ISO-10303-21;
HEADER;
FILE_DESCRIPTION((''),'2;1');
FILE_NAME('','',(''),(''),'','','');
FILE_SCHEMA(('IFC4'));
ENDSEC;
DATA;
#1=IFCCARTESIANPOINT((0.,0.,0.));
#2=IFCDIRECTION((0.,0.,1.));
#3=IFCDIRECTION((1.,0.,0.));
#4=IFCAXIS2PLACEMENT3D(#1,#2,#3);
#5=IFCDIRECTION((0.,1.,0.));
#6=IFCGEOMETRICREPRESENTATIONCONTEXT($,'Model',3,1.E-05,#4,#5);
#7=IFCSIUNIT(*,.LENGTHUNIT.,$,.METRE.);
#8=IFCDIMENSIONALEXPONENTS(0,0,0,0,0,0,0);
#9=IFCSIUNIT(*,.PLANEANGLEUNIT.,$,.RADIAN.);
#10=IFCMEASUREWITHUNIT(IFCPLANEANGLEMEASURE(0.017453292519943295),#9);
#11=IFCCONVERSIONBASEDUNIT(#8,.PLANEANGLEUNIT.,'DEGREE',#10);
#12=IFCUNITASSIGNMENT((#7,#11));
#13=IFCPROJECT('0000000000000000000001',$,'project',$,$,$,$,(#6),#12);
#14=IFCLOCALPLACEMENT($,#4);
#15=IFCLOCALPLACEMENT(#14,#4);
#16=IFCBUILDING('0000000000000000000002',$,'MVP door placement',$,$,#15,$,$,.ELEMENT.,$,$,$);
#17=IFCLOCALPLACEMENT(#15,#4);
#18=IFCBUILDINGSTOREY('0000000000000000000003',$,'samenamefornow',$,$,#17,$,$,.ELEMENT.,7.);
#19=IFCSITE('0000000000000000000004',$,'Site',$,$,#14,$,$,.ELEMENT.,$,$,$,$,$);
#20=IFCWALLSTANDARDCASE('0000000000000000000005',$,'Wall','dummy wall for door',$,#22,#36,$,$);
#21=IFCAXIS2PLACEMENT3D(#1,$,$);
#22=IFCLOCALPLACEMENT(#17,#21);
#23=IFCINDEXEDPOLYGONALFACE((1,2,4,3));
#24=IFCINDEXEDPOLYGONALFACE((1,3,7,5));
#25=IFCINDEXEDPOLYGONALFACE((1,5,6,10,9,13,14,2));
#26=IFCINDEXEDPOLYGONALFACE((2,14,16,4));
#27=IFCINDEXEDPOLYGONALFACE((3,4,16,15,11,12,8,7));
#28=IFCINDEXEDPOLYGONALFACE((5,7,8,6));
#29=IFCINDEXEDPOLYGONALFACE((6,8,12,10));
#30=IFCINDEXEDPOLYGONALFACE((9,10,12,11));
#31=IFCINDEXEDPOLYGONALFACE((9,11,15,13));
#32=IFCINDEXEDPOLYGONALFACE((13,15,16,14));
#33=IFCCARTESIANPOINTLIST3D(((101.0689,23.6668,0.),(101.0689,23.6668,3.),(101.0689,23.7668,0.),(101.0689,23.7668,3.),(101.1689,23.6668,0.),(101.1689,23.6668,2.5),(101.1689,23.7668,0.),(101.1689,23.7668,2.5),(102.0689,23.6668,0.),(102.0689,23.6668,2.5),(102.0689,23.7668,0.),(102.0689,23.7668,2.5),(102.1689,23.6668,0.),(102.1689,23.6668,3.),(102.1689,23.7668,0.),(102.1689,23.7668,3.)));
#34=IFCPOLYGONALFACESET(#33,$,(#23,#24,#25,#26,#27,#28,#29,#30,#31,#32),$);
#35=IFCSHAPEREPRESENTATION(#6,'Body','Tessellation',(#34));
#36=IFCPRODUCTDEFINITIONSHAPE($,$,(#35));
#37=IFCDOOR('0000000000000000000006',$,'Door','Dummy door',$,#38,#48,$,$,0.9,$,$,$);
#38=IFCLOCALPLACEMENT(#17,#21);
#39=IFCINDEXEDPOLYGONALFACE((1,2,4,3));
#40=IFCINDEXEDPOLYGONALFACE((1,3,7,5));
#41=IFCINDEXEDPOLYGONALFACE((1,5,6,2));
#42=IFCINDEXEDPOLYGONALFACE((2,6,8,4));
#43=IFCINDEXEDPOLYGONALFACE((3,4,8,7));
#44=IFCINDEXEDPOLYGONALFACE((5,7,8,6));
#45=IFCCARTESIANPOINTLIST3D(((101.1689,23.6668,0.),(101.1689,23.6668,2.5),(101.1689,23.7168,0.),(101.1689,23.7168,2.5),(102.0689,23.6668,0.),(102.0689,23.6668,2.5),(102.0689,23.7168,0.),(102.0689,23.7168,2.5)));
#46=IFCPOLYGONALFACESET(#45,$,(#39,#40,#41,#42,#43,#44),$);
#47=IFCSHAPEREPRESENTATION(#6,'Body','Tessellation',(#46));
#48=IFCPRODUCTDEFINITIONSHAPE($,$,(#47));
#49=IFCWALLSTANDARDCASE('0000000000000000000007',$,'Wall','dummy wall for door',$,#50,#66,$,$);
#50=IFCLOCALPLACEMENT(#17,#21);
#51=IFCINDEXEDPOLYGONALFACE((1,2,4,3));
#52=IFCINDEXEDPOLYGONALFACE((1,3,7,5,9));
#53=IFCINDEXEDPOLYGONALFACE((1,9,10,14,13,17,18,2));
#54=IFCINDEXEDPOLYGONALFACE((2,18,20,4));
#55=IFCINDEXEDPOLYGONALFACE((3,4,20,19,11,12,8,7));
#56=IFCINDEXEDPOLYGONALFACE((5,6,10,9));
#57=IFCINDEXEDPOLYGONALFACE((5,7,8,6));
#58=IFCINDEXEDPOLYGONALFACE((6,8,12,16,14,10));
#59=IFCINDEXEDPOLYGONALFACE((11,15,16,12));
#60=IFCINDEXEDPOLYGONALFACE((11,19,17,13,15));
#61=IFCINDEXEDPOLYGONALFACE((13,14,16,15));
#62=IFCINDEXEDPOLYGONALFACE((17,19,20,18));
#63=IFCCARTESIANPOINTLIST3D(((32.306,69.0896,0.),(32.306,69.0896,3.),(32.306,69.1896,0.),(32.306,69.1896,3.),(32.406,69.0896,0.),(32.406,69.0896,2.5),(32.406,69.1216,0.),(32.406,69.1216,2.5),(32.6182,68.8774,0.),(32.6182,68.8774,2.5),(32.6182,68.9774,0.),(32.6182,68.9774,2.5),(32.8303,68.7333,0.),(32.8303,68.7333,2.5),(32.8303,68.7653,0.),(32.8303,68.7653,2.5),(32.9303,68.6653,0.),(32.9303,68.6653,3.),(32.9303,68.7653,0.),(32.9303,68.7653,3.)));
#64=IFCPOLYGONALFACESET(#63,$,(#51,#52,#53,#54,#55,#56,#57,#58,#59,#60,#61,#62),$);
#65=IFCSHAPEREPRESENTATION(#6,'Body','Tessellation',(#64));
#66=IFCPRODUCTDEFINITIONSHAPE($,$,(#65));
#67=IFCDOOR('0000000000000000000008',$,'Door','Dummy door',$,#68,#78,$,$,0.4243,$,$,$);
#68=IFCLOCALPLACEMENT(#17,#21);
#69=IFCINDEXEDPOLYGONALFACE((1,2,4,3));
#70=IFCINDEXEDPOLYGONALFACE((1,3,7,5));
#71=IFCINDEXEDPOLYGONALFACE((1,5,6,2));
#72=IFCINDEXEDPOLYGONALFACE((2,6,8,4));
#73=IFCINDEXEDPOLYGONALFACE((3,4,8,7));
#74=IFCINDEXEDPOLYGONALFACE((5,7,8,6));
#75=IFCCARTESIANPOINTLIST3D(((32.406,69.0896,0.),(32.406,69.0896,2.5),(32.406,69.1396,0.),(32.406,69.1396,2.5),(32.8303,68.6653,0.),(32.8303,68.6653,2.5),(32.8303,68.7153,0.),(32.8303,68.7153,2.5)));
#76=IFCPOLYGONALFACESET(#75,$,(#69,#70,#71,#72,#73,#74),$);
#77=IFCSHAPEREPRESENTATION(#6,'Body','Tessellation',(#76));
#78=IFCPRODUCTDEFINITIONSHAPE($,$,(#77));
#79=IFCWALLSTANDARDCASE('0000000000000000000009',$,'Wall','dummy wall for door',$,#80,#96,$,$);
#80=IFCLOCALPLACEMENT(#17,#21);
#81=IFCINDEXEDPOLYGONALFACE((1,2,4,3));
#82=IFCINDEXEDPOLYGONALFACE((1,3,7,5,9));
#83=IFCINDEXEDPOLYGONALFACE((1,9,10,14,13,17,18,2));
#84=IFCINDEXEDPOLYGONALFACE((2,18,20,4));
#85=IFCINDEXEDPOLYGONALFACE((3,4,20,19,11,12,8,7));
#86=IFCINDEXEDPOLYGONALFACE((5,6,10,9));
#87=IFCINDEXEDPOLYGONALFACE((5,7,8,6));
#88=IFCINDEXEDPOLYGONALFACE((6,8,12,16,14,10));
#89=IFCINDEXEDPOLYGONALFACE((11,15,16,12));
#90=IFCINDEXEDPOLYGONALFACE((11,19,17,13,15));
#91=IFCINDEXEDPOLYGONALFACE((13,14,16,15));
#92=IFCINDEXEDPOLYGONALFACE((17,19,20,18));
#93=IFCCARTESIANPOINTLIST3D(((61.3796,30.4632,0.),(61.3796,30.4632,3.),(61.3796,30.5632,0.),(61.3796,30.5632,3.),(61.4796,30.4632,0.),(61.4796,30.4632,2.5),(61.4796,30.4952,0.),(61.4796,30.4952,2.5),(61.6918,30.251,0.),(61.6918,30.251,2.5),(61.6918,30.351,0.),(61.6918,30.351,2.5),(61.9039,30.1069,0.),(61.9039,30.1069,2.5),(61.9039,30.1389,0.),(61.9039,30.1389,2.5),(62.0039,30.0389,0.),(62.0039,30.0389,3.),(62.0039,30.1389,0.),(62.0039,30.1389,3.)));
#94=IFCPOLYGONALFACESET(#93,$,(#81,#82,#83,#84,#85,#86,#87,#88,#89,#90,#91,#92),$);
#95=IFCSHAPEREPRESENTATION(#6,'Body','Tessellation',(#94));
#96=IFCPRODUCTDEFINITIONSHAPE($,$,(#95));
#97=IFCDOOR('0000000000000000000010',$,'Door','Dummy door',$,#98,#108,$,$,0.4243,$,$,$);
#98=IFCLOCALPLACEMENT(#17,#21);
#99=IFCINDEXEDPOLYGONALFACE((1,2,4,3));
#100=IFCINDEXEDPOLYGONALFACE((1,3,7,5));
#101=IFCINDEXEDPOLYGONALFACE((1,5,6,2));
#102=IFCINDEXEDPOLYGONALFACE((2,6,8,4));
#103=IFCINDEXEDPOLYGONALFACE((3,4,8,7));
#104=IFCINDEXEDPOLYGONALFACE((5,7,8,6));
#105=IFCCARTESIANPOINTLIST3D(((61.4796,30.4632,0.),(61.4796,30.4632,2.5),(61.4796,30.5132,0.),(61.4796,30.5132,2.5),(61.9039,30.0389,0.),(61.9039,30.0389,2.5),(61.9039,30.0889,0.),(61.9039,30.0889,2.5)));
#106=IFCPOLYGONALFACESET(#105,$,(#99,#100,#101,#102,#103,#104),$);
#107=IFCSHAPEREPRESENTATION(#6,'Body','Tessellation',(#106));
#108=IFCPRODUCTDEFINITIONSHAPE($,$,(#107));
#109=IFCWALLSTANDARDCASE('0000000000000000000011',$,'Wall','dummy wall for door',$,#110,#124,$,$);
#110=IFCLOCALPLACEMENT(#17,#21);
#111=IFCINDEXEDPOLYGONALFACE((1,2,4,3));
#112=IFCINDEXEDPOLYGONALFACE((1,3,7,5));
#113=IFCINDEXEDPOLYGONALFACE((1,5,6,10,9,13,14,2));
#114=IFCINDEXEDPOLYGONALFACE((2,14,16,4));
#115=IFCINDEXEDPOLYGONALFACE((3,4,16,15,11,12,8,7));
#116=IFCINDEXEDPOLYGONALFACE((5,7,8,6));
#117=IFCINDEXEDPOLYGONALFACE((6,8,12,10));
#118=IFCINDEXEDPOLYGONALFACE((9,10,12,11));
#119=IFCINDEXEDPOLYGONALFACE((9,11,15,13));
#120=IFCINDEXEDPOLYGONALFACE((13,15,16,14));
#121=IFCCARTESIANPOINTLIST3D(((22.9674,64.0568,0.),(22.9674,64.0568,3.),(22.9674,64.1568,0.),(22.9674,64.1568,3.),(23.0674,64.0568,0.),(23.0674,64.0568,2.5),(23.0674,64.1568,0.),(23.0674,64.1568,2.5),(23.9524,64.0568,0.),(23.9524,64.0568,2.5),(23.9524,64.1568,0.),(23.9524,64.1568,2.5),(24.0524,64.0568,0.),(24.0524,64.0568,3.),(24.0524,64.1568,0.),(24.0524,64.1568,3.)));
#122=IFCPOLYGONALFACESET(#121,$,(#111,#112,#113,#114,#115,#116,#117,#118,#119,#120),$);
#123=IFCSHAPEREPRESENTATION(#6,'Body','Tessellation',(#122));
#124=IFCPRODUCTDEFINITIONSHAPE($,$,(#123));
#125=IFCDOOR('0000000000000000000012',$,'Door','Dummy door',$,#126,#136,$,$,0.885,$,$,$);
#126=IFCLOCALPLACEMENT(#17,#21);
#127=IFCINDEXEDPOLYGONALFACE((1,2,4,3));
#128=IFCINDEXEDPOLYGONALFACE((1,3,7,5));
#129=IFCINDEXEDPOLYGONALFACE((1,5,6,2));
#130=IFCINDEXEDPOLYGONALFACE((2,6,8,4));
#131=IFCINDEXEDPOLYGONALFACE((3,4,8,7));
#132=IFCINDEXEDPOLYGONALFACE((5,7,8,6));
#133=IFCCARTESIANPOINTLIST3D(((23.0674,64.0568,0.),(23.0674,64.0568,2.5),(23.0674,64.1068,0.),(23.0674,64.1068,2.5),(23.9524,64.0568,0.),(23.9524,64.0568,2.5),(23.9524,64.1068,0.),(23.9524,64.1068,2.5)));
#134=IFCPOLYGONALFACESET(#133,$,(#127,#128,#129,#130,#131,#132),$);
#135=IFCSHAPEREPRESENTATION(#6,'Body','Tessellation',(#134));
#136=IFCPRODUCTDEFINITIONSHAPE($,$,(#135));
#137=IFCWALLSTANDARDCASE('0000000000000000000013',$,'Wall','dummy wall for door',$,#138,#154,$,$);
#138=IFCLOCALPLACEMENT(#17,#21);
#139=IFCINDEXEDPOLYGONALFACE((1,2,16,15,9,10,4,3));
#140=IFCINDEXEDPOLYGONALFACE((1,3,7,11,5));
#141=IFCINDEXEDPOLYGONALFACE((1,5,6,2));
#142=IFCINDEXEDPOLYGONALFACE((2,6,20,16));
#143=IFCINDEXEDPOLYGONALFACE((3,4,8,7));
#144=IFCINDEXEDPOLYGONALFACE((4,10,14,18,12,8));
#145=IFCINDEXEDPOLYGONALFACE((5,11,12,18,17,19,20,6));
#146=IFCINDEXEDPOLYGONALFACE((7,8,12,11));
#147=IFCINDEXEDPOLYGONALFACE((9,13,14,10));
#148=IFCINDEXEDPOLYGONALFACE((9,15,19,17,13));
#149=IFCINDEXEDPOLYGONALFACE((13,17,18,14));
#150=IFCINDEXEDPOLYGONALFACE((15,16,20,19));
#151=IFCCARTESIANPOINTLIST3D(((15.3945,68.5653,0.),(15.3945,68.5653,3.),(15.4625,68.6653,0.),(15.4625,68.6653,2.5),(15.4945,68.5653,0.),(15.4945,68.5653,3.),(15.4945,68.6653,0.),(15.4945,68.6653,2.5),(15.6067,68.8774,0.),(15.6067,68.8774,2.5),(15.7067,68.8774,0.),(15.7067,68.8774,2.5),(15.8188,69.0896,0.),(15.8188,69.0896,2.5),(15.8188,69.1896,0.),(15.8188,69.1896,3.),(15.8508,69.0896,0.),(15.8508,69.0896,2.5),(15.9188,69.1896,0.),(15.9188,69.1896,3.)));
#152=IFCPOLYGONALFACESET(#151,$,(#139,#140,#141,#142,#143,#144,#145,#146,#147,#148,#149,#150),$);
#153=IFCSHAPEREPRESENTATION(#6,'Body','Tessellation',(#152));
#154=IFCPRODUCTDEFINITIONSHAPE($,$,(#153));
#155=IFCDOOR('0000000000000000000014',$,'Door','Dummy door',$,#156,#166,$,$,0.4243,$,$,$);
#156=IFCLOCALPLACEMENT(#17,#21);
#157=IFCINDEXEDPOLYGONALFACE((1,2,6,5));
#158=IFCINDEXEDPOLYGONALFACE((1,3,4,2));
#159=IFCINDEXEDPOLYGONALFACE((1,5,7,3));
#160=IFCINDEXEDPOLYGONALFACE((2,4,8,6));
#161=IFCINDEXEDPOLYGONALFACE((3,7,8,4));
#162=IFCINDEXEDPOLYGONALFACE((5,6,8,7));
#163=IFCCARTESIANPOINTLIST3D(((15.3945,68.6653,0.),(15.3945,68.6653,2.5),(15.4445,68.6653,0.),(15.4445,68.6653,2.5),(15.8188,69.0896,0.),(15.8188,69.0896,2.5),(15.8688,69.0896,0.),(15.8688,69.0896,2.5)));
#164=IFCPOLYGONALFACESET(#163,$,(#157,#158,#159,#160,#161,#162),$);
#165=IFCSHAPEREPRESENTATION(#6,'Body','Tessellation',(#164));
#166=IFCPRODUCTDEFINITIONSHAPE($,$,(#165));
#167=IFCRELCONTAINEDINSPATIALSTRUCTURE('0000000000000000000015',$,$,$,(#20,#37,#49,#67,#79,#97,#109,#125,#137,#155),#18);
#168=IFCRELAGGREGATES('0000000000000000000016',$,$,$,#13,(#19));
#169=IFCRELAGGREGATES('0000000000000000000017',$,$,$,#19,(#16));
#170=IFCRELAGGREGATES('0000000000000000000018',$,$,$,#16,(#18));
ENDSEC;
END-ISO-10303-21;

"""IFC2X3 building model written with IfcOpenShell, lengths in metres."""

from ifc_helpers import new_model, entity, si_unit, converted_unit, direction, origin_with_axes, place, context, project, spatial, polyline, outline, extrude, element, fill, save


model = new_model("IFC2X3")

# Units and contexts
model_context = context("Model", 3, precision=1e-05, world=origin_with_axes(), true_north=direction((0.0, 1.0, 0.0)))
ifc_project = project(units=[si_unit("LENGTHUNIT", "METRE"), converted_unit("PLANEANGLEUNIT", "DEGREE", entity("IfcPlaneAngleMeasure", 0.017453292519943295), si_unit("PLANEANGLEUNIT", "RADIAN"), dimensions=[0, 0, 0, 0, 0, 0, 0])], contexts=[model_context])

# Site, building, storey
site_placement = place(None, origin_with_axes())
site = spatial("IfcSite", under=ifc_project, at=site_placement, Name="Site", CompositionType="ELEMENT")
building_placement = place(site_placement, origin_with_axes())
building = spatial("IfcBuilding", under=site, at=building_placement, Name="MVP door placement", CompositionType="ELEMENT")
storey_placement = place(building_placement, origin_with_axes())
storey = spatial("IfcBuildingStorey", under=building, at=storey_placement, Name="samenamefornow", CompositionType="ELEMENT", Elevation=7.0)

# Walls, openings, doors
wall_1_placement = place(storey_placement, origin_with_axes())
wall_1 = element("IfcWallStandardCase", 1, at=wall_1_placement, inside=storey, Name="Wall", Description="dummy wall for door", context=model_context, shape_type="SweptSolid", body=[
    extrude(outline(polyline([(101.0689, 23.6668, 0.0), (102.1689, 23.6668, 0.0), (102.1689, 23.7668, 0.0), (101.0689, 23.7668, 0.0), (101.0689, 23.6668, 0.0)])), origin_with_axes(), (0.0, 0.0, 1.0), 3.0),
])
opening_1_placement = place(wall_1_placement, origin_with_axes())
opening_1 = element("IfcOpeningElement", 2, at=opening_1_placement, cuts=wall_1, context=model_context, shape_type="SweptSolid", body=[
    extrude(outline(polyline([(101.1689, 23.6668, 0.0), (102.0689, 23.6668, 0.0), (102.0689, 23.7668, 0.0), (101.1689, 23.7668, 0.0), (101.1689, 23.6668, 0.0)])), origin_with_axes(), (0.0, 0.0, 1.0), 2.5),
])
door_1_placement = place(opening_1_placement, origin_with_axes())
door_1 = element("IfcDoor", 3, at=door_1_placement, inside=storey, Name="Door", Description="Dummy door", OverallWidth=0.9, context=model_context, shape_type="SweptSolid", body=[
    extrude(outline(polyline([(101.1689, 23.6668, 0.0), (102.0689, 23.6668, 0.0), (102.0689, 23.7168, 0.0), (101.1689, 23.7168, 0.0), (101.1689, 23.6668, 0.0)])), origin_with_axes(), (0.0, 0.0, 1.0), 2.5),
])
fill(opening_1, door_1)
wall_2_placement = place(storey_placement, origin_with_axes())
wall_2 = element("IfcWallStandardCase", 4, at=wall_2_placement, inside=storey, Name="Wall", Description="dummy wall for door", context=model_context, shape_type="SweptSolid", body=[
    extrude(outline(polyline([(32.306, 69.0896, 0.0), (32.9303, 68.6653, 0.0), (32.9303, 68.7653, 0.0), (32.306, 69.1896, 0.0), (32.306, 69.0896, 0.0)])), origin_with_axes(), (0.0, 0.0, 1.0), 3.0),
])
opening_2_placement = place(wall_2_placement, origin_with_axes())
opening_2 = element("IfcOpeningElement", 5, at=opening_2_placement, cuts=wall_2, context=model_context, shape_type="SweptSolid", body=[
    extrude(outline(polyline([(32.406, 69.0896, 0.0), (32.8303, 68.6653, 0.0), (32.8303, 68.7653, 0.0), (32.406, 69.1896, 0.0), (32.406, 69.0896, 0.0)])), origin_with_axes(), (0.0, 0.0, 1.0), 2.5),
])
door_2_placement = place(opening_2_placement, origin_with_axes())
door_2 = element("IfcDoor", 6, at=door_2_placement, inside=storey, Name="Door", Description="Dummy door", OverallWidth=0.4243, context=model_context, shape_type="SweptSolid", body=[
    extrude(outline(polyline([(32.406, 69.0896, 0.0), (32.8303, 68.6653, 0.0), (32.8303, 68.7153, 0.0), (32.406, 69.1396, 0.0), (32.406, 69.0896, 0.0)])), origin_with_axes(), (0.0, 0.0, 1.0), 2.5),
])
fill(opening_2, door_2)
wall_3_placement = place(storey_placement, origin_with_axes())
wall_3 = element("IfcWallStandardCase", 7, at=wall_3_placement, inside=storey, Name="Wall", Description="dummy wall for door", context=model_context, shape_type="SweptSolid", body=[
    extrude(outline(polyline([(61.3796, 30.4632, 0.0), (62.0039, 30.0389, 0.0), (62.0039, 30.1389, 0.0), (61.3796, 30.5632, 0.0), (61.3796, 30.4632, 0.0)])), origin_with_axes(), (0.0, 0.0, 1.0), 3.0),
])
opening_3_placement = place(wall_3_placement, origin_with_axes())
opening_3 = element("IfcOpeningElement", 8, at=opening_3_placement, cuts=wall_3, context=model_context, shape_type="SweptSolid", body=[
    extrude(outline(polyline([(61.4796, 30.4632, 0.0), (61.9039, 30.0389, 0.0), (61.9039, 30.1389, 0.0), (61.4796, 30.5632, 0.0), (61.4796, 30.4632, 0.0)])), origin_with_axes(), (0.0, 0.0, 1.0), 2.5),
])
door_3_placement = place(opening_3_placement, origin_with_axes())
door_3 = element("IfcDoor", 9, at=door_3_placement, inside=storey, Name="Door", Description="Dummy door", OverallWidth=0.4243, context=model_context, shape_type="SweptSolid", body=[
    extrude(outline(polyline([(61.4796, 30.4632, 0.0), (61.9039, 30.0389, 0.0), (61.9039, 30.0889, 0.0), (61.4796, 30.5132, 0.0), (61.4796, 30.4632, 0.0)])), origin_with_axes(), (0.0, 0.0, 1.0), 2.5),
])
fill(opening_3, door_3)
wall_4_placement = place(storey_placement, origin_with_axes())
wall_4 = element("IfcWallStandardCase", 10, at=wall_4_placement, inside=storey, Name="Wall", Description="dummy wall for door", context=model_context, shape_type="SweptSolid", body=[
    extrude(outline(polyline([(22.9674, 64.0568, 0.0), (24.0524, 64.0568, 0.0), (24.0524, 64.1568, 0.0), (22.9674, 64.1568, 0.0), (22.9674, 64.0568, 0.0)])), origin_with_axes(), (0.0, 0.0, 1.0), 3.0),
])
opening_4_placement = place(wall_4_placement, origin_with_axes())
opening_4 = element("IfcOpeningElement", 11, at=opening_4_placement, cuts=wall_4, context=model_context, shape_type="SweptSolid", body=[
    extrude(outline(polyline([(23.0674, 64.0568, 0.0), (23.9524, 64.0568, 0.0), (23.9524, 64.1568, 0.0), (23.0674, 64.1568, 0.0), (23.0674, 64.0568, 0.0)])), origin_with_axes(), (0.0, 0.0, 1.0), 2.5),
])
door_4_placement = place(opening_4_placement, origin_with_axes())
door_4 = element("IfcDoor", 12, at=door_4_placement, inside=storey, Name="Door", Description="Dummy door", OverallWidth=0.885, context=model_context, shape_type="SweptSolid", body=[
    extrude(outline(polyline([(23.0674, 64.0568, 0.0), (23.9524, 64.0568, 0.0), (23.9524, 64.1068, 0.0), (23.0674, 64.1068, 0.0), (23.0674, 64.0568, 0.0)])), origin_with_axes(), (0.0, 0.0, 1.0), 2.5),
])
fill(opening_4, door_4)
wall_5_placement = place(storey_placement, origin_with_axes())
wall_5 = element("IfcWallStandardCase", 13, at=wall_5_placement, inside=storey, Name="Wall", Description="dummy wall for door", context=model_context, shape_type="SweptSolid", body=[
    extrude(outline(polyline([(15.8188, 69.1896, 0.0), (15.3945, 68.5653, 0.0), (15.4945, 68.5653, 0.0), (15.9188, 69.1896, 0.0), (15.8188, 69.1896, 0.0)])), origin_with_axes(), (0.0, 0.0, 1.0), 3.0),
])
opening_5_placement = place(wall_5_placement, origin_with_axes())
opening_5 = element("IfcOpeningElement", 14, at=opening_5_placement, cuts=wall_5, context=model_context, shape_type="SweptSolid", body=[
    extrude(outline(polyline([(15.8188, 69.0896, 0.0), (15.3945, 68.6653, 0.0), (15.4945, 68.6653, 0.0), (15.9188, 69.0896, 0.0), (15.8188, 69.0896, 0.0)])), origin_with_axes(), (0.0, 0.0, 1.0), 2.5),
])
door_5_placement = place(opening_5_placement, origin_with_axes())
door_5 = element("IfcDoor", 15, at=door_5_placement, inside=storey, Name="Door", Description="Dummy door", OverallWidth=0.4243, context=model_context, shape_type="SweptSolid", body=[
    extrude(outline(polyline([(15.8188, 69.0896, 0.0), (15.3945, 68.6653, 0.0), (15.4445, 68.6653, 0.0), (15.8688, 69.0896, 0.0), (15.8188, 69.0896, 0.0)])), origin_with_axes(), (0.0, 0.0, 1.0), 2.5),
])
fill(opening_5, door_5)

save(model, "model.ifc")
